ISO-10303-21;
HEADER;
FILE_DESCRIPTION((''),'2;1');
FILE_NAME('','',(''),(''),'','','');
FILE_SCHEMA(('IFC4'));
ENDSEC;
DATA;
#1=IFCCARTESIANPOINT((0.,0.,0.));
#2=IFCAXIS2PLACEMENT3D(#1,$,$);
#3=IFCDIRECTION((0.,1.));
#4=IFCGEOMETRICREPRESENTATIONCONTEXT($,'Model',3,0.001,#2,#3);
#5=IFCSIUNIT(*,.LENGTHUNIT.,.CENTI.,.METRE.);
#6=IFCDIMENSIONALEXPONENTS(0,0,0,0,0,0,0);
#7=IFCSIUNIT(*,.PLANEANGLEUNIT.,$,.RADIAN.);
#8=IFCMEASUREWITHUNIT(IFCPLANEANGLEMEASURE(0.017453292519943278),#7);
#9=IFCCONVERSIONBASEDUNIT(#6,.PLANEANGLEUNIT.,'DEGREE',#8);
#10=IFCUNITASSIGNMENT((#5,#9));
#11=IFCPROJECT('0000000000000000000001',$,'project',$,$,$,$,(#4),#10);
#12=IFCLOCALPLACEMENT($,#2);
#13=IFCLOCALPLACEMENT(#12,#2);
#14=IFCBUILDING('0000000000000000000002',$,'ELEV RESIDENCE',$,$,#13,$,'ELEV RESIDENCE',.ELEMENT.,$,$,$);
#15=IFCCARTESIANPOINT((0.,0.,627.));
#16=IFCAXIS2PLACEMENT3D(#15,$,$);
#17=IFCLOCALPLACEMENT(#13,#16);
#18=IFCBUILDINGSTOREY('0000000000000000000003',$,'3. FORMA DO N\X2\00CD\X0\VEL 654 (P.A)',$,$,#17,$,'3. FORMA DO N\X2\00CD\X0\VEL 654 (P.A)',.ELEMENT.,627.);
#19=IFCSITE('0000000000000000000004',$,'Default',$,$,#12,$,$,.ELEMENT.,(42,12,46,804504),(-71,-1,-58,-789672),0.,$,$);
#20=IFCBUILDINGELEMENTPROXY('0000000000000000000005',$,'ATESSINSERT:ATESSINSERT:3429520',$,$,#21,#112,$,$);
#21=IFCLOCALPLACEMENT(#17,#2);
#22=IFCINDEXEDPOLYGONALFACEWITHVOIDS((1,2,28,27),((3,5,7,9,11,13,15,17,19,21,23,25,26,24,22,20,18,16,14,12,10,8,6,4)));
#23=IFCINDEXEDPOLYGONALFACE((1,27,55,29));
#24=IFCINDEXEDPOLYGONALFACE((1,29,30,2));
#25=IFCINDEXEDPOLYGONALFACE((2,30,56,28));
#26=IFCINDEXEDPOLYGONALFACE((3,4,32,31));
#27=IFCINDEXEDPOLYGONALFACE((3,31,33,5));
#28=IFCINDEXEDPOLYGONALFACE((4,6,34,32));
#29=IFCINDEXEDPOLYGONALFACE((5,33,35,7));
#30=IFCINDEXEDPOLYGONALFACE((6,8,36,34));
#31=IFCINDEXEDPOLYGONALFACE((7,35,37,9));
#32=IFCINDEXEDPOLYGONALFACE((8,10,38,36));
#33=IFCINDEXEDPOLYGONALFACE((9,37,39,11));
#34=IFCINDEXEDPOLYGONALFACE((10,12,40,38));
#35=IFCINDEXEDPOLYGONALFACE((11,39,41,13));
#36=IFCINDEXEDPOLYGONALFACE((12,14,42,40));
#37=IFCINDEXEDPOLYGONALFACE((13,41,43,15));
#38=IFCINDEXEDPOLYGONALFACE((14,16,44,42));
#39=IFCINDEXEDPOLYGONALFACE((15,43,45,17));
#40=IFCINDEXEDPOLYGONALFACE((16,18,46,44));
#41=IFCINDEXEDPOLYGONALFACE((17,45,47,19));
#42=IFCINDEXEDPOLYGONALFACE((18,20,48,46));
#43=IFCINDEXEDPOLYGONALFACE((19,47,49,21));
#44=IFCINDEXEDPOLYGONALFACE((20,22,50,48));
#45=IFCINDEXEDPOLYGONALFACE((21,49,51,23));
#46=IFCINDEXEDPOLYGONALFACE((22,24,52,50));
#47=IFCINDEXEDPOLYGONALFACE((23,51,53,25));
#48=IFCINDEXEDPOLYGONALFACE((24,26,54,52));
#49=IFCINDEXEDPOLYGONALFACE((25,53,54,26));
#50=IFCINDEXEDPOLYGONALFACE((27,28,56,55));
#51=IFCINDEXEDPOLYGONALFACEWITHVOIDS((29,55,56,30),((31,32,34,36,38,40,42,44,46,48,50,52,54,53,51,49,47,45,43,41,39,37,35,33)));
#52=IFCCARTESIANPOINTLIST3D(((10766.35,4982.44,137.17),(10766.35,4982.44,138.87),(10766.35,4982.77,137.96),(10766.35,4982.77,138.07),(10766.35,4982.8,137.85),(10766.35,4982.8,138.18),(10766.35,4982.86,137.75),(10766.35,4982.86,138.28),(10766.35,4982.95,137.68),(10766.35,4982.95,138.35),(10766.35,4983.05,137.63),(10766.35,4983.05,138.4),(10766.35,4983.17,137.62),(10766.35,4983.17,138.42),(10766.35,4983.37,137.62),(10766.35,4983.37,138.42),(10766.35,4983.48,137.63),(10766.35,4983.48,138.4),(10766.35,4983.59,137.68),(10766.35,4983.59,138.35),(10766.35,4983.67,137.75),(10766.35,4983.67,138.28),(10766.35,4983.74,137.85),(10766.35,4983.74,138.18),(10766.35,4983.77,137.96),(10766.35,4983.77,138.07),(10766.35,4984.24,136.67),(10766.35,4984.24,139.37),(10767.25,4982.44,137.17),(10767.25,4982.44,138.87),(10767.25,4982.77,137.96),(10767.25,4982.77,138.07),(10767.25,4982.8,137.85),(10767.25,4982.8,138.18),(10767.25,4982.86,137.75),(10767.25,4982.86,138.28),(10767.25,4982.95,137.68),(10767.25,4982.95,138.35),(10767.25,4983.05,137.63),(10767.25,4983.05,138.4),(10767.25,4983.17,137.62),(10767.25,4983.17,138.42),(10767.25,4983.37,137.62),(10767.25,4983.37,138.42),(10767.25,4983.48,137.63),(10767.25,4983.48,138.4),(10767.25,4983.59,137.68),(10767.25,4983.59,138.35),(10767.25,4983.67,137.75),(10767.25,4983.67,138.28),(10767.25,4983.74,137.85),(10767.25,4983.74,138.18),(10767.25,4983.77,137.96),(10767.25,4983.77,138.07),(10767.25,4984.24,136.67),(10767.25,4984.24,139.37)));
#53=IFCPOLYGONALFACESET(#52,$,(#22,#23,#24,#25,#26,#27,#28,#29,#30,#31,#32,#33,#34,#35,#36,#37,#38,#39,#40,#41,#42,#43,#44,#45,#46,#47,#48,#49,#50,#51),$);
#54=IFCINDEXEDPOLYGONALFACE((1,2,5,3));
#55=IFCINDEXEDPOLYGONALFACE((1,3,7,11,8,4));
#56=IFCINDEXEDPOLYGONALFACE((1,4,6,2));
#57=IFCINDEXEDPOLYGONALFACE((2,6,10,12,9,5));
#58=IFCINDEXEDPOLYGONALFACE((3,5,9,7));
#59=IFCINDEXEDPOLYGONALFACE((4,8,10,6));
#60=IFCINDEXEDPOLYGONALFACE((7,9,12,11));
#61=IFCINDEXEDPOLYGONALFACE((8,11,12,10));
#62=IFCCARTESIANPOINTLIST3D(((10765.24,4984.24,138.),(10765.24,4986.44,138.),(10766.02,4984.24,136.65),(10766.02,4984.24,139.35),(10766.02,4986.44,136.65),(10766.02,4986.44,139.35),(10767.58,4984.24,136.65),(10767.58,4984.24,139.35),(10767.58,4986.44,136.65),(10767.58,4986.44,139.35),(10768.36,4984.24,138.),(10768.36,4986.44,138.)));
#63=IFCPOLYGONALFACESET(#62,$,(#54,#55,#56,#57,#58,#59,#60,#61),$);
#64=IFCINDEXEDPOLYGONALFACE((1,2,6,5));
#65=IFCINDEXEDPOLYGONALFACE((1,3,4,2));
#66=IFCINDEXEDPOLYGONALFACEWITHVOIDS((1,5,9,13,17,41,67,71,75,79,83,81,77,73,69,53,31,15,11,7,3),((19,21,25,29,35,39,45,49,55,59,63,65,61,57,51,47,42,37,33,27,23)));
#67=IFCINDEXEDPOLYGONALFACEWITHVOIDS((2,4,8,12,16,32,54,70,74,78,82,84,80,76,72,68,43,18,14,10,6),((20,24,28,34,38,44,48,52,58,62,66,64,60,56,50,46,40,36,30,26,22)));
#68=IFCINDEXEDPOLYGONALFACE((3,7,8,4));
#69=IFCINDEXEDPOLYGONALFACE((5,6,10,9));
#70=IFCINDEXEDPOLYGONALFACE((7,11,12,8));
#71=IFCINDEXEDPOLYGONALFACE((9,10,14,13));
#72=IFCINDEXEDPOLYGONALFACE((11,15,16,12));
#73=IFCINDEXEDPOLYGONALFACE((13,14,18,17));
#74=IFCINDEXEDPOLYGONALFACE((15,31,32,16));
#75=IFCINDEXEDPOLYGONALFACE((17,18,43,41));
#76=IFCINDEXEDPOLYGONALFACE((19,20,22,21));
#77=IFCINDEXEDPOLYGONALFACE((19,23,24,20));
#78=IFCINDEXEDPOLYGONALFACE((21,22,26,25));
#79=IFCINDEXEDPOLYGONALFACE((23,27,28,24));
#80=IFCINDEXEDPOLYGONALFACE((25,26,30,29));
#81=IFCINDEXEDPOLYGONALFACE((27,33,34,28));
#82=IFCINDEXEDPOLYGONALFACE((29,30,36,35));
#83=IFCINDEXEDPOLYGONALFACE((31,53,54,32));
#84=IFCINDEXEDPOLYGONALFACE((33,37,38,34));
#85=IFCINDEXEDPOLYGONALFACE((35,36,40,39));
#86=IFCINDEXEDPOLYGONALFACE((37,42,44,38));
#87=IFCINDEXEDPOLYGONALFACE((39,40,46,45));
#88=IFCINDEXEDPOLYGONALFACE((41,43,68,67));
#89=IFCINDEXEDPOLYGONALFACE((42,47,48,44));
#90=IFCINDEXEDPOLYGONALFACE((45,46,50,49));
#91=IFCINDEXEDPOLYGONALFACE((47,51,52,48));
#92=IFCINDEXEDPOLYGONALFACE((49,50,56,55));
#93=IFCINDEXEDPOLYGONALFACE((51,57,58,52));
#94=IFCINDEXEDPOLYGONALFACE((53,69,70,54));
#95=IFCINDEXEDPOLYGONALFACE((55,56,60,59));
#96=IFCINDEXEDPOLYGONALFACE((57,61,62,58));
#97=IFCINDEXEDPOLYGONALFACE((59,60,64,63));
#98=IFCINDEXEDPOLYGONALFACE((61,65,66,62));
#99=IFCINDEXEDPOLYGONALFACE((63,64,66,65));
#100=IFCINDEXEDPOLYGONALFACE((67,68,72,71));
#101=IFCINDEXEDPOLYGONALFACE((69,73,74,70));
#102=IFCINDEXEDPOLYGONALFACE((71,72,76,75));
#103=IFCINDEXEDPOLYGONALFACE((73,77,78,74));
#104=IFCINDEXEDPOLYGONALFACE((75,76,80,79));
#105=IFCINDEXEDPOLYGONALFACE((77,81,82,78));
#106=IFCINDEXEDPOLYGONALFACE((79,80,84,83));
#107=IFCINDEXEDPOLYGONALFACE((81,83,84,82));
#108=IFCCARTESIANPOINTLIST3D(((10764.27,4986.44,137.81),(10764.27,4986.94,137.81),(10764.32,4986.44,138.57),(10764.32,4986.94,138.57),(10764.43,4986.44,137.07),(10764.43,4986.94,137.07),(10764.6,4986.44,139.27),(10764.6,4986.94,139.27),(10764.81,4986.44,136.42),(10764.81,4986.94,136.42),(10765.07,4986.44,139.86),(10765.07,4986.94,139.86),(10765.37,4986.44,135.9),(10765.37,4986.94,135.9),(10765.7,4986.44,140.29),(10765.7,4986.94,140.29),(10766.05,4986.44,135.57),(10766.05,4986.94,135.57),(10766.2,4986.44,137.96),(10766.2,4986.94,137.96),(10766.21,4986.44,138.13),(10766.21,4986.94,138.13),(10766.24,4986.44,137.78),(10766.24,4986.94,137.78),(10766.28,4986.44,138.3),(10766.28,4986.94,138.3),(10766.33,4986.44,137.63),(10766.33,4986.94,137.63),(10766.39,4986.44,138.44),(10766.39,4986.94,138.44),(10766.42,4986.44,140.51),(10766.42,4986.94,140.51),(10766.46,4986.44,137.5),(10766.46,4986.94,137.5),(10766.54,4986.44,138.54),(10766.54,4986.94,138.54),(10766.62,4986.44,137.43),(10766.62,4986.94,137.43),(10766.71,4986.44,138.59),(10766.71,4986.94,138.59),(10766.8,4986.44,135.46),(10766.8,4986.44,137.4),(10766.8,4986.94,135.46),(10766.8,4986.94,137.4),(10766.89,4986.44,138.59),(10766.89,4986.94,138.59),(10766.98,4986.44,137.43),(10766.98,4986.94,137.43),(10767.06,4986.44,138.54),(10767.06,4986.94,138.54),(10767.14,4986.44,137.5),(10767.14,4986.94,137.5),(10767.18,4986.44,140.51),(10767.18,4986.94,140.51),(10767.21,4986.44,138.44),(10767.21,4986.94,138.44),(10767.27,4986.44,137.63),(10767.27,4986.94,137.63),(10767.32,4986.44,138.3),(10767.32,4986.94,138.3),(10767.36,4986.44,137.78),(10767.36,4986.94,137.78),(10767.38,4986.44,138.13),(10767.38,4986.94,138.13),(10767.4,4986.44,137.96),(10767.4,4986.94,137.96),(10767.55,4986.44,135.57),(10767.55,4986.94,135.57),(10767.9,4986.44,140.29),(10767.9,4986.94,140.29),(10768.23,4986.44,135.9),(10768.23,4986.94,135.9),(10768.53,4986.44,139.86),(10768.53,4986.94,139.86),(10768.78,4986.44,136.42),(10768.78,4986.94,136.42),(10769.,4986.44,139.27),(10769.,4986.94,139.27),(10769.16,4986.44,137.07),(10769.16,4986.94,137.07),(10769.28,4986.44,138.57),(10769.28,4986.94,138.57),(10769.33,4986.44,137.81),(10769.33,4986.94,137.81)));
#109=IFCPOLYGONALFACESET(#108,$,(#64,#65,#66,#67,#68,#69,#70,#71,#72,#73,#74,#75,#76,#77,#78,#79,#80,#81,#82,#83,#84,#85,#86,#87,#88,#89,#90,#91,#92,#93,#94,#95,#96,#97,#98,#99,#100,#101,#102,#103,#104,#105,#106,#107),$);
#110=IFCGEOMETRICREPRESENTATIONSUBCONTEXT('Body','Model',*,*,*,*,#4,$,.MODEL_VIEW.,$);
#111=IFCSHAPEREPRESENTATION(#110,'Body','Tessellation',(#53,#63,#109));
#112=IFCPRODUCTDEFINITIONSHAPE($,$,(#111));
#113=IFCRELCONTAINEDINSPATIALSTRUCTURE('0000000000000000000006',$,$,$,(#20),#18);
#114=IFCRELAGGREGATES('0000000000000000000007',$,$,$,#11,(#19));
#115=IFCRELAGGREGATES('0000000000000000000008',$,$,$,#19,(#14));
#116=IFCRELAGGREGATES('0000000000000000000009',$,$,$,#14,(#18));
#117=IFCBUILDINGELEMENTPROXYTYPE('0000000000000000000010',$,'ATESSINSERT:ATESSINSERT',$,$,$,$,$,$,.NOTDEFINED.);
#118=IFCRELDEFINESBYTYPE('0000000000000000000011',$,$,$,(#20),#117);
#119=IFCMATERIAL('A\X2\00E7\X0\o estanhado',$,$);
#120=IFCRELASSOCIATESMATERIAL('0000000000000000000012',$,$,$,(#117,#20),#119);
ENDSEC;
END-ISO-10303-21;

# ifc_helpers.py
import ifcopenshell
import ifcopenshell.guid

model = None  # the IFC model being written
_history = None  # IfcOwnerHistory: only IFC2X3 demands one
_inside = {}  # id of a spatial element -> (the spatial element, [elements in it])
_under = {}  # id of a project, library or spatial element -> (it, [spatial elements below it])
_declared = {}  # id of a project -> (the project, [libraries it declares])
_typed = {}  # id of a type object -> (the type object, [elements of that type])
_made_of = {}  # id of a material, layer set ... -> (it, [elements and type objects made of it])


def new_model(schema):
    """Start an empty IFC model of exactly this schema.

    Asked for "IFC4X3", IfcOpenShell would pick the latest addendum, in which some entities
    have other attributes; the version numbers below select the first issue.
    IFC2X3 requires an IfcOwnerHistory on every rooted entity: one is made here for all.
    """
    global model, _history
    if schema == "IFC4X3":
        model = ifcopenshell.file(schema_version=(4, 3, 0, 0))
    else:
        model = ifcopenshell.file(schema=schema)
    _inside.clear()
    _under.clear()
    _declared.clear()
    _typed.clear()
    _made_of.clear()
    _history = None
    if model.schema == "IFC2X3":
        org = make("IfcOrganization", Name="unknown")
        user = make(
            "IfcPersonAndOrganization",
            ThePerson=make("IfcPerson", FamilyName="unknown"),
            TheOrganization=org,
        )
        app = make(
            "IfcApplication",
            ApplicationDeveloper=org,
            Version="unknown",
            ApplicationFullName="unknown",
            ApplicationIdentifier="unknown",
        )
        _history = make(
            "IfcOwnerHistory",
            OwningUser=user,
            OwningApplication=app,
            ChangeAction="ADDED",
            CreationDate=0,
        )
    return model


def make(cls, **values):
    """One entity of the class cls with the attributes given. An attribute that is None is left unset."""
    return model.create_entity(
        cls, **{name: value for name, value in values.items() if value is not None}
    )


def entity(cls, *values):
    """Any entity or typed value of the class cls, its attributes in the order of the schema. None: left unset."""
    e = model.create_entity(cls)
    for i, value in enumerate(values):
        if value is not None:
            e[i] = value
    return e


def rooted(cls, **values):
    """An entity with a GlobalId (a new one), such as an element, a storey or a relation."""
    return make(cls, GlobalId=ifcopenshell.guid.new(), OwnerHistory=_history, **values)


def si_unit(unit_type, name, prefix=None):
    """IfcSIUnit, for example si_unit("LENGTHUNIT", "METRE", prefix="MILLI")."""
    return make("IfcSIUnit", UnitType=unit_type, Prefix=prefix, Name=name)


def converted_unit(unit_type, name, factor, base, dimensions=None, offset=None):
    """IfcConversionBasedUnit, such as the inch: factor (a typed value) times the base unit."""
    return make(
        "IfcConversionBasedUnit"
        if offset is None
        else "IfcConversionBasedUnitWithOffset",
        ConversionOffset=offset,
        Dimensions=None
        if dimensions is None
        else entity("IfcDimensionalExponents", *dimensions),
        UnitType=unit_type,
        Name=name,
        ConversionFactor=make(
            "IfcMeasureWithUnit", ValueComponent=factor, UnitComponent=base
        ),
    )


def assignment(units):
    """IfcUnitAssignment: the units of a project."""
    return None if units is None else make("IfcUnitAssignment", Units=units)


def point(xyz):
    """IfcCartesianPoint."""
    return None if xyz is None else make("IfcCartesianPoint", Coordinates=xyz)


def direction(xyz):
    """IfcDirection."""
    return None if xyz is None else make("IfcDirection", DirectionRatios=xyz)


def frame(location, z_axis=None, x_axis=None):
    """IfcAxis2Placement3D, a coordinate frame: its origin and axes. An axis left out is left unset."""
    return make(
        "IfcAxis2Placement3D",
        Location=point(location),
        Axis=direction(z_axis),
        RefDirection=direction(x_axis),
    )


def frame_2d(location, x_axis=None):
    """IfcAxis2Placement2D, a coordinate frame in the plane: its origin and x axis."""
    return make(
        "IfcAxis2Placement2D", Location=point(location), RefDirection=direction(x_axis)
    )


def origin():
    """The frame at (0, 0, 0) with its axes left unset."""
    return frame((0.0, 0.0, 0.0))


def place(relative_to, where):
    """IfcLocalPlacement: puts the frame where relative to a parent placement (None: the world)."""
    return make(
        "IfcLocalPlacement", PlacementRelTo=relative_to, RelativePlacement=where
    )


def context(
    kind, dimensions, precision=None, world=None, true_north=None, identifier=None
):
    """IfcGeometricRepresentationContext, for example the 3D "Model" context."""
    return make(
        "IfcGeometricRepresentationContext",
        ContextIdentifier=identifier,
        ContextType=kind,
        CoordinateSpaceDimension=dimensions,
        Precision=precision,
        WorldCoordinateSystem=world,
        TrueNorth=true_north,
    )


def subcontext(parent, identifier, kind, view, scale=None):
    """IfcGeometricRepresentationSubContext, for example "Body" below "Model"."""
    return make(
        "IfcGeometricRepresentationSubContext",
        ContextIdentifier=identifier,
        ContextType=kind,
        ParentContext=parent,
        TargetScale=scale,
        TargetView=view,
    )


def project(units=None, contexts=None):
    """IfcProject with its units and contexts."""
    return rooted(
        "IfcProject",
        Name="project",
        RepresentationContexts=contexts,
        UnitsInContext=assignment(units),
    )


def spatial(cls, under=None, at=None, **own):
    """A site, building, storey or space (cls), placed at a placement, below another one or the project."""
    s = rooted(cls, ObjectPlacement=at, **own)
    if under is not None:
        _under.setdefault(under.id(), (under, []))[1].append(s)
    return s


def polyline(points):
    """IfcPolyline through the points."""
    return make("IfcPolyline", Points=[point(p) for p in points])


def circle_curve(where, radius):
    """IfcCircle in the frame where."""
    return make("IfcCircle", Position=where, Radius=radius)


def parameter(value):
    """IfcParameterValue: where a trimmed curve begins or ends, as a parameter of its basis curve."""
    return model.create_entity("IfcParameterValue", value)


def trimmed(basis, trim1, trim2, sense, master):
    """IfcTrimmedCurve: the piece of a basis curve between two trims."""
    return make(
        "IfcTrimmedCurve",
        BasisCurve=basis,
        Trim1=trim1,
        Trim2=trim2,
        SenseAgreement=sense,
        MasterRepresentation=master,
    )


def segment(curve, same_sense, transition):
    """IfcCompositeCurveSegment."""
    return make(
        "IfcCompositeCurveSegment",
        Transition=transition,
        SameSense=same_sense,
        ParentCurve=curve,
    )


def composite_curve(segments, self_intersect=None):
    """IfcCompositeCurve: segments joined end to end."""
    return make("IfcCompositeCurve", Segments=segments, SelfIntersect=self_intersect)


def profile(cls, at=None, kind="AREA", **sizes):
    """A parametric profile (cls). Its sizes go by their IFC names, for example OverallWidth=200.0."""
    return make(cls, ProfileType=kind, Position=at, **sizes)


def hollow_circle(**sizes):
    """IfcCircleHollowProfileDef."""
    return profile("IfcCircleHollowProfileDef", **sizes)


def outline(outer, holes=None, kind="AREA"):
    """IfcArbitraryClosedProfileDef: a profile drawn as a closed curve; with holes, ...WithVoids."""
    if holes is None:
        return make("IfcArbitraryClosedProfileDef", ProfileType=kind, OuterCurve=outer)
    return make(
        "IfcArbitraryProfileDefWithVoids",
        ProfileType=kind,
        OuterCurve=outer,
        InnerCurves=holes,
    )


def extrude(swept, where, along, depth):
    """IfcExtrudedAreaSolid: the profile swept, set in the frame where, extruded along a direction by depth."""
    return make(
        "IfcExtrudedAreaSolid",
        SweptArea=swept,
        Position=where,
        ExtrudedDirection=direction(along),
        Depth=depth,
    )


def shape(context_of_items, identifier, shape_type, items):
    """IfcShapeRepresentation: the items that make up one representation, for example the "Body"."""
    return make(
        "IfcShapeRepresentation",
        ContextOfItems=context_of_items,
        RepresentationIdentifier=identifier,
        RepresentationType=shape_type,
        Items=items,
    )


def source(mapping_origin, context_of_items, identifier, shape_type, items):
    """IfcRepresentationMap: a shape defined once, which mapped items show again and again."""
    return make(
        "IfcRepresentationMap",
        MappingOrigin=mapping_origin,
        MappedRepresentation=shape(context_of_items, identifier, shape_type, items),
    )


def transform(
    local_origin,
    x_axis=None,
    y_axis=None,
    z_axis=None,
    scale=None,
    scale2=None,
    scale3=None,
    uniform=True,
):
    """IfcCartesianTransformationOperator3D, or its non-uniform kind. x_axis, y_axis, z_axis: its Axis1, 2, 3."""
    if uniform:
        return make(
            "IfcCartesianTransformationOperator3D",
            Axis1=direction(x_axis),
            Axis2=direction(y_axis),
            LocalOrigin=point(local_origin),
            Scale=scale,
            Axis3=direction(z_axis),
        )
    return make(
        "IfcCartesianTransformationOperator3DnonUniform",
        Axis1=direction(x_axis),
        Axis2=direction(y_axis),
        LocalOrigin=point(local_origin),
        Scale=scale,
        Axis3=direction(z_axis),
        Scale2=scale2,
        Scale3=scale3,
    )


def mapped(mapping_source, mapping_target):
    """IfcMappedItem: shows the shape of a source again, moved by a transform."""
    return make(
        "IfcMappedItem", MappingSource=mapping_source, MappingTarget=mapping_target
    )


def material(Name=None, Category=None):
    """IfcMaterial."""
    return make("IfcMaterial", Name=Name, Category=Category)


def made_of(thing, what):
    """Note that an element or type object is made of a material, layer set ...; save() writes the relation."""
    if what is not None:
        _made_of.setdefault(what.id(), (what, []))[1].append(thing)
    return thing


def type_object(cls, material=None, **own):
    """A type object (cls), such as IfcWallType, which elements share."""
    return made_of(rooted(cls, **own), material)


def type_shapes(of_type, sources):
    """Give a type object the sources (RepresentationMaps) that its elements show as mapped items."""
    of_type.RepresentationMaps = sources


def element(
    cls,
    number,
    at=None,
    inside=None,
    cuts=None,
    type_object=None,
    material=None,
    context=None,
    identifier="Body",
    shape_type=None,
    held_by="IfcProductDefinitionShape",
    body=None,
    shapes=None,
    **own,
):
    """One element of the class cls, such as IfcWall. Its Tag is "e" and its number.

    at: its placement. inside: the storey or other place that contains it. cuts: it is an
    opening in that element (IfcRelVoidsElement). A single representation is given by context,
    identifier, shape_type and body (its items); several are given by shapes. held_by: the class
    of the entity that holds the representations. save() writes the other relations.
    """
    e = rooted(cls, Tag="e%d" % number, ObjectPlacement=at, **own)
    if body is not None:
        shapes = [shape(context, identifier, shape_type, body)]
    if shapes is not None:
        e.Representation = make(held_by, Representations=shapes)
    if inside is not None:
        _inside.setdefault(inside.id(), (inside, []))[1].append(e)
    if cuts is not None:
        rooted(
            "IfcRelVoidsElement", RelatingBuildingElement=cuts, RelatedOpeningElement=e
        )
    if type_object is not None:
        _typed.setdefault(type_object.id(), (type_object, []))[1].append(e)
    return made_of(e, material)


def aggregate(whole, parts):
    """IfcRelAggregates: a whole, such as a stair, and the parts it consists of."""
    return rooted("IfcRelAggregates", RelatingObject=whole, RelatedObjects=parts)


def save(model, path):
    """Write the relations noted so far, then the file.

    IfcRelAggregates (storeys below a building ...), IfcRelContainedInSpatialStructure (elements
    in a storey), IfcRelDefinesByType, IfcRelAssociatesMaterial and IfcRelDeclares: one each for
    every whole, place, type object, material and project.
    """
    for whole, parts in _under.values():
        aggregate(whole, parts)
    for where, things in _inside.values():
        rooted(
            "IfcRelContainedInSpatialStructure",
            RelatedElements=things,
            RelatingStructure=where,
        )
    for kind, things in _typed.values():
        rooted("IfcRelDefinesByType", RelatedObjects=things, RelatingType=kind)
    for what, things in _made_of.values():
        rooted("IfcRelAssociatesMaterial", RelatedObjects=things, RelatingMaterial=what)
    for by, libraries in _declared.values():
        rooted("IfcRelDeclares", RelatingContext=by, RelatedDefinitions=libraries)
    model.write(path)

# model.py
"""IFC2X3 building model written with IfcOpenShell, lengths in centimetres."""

from ifc_helpers import new_model, entity, si_unit, converted_unit, direction, frame, frame_2d, origin, place, context, subcontext, project, spatial, polyline, circle_curve, parameter, trimmed, segment, composite_curve, hollow_circle, outline, extrude, source, transform, mapped, material, type_object, type_shapes, element, save


model = new_model("IFC2X3")

# Units and contexts
model_context = context("Model", 3, precision=0.001, world=origin(), true_north=direction((0.0, 1.0)))
body_context = subcontext(model_context, "Body", "Model", "MODEL_VIEW")
ifc_project = project(units=[si_unit("LENGTHUNIT", "METRE", prefix="CENTI"), converted_unit("PLANEANGLEUNIT", "DEGREE", entity("IfcPlaneAngleMeasure", 0.017453292519943278), si_unit("PLANEANGLEUNIT", "RADIAN"), dimensions=[0, 0, 0, 0, 0, 0, 0])], contexts=[model_context])

# Site, building, storey
site_placement = place(None, origin())
site = spatial("IfcSite", under=ifc_project, at=site_placement, Name="Default", CompositionType="ELEMENT", RefLatitude=(42, 12, 46, 804504), RefLongitude=(-71, -1, -58, -789672), RefElevation=0.0)
building_placement = place(site_placement, origin())
building = spatial("IfcBuilding", under=site, at=building_placement, Name="ELEV RESIDENCE", LongName="ELEV RESIDENCE", CompositionType="ELEMENT")
storey_placement = place(building_placement, frame((0.0, 0.0, 627.0)))
storey = spatial("IfcBuildingStorey", under=building, at=storey_placement, Name="3. FORMA DO NÍVEL 654 (P.A)", LongName="3. FORMA DO NÍVEL 654 (P.A)", CompositionType="ELEMENT", Elevation=627.0)

# Building element proxy
ifc_material_1 = material(Name="Aço estanhado")
building_element_proxy_type = type_object("IfcBuildingElementProxyType", Name="ATESSINSERT:ATESSINSERT", PredefinedType="NOTDEFINED", material=ifc_material_1)
shared_shape = source(origin(), body_context, "Body", "SweptSolid", [
    extrude(outline(polyline([(-1.35, -0.9), (1.35, -0.9), (0.85, 0.9), (-0.85, 0.9), (-1.35, -0.9)]), holes=[composite_curve([segment(trimmed(circle_curve(frame_2d((0.0, 0.17), x_axis=(1.0, 0.0)), 0.4), [parameter(0.0)], [parameter(180.0)], True, "PARAMETER"), False, "CONTINUOUS"), segment(polyline([(0.4, 0.17), (0.4, -0.03)]), True, "CONTINUOUS"), segment(trimmed(circle_curve(frame_2d((0.0, -0.03), x_axis=(1.0, 0.0)), 0.4), [parameter(180.0)], [parameter(0.0)], True, "PARAMETER"), False, "CONTINUOUS"), segment(polyline([(-0.4, -0.03), (-0.4, 0.17)]), True, "CONTINUOUS")], self_intersect=False)]), frame((-1.4, -0.45, 30.02), z_axis=(0.0, 1.0, 0.0), x_axis=(0.0, 0.0, 1.0)), (0.0, 0.0, 1.0), 0.9),
    extrude(outline(polyline([(-0.78, -1.35), (0.78, -1.35), (1.56, 0.0), (0.78, 1.35), (-0.78, 1.35), (-1.56, 0.0), (-0.78, -1.35)])), frame((-4.5, 0.0, 30.0), z_axis=(1.0, 0.0, 0.0), x_axis=(0.0, 1.0, 0.0)), (0.0, 0.0, 1.0), 2.2),
    extrude(hollow_circle(Radius=2.54, WallThickness=1.94, at=frame_2d((0.0, 0.0), x_axis=(1.0, 0.0))), frame((-5.0, 0.0, 30.0), z_axis=(1.0, 0.0, 0.0), x_axis=(0.0, 0.0, -1.0)), (0.0, 0.0, 1.0), 0.5),
])
type_shapes(building_element_proxy_type, [shared_shape])
proxy_placement = place(storey_placement, frame((10766.8, 4981.94, 108.0), z_axis=(0.0, 0.0, 1.0), x_axis=(0.0, -1.0, 0.0)))
element("IfcBuildingElementProxy", 1, at=proxy_placement, inside=storey, type_object=building_element_proxy_type, material=ifc_material_1, Name="ATESSINSERT:ATESSINSERT:3429520", context=body_context, shape_type="MappedRepresentation", body=[
    mapped(shared_shape, transform((0.0, 0.0, 0.0), scale=1.0)),
])

save(model, "model.ifc")
